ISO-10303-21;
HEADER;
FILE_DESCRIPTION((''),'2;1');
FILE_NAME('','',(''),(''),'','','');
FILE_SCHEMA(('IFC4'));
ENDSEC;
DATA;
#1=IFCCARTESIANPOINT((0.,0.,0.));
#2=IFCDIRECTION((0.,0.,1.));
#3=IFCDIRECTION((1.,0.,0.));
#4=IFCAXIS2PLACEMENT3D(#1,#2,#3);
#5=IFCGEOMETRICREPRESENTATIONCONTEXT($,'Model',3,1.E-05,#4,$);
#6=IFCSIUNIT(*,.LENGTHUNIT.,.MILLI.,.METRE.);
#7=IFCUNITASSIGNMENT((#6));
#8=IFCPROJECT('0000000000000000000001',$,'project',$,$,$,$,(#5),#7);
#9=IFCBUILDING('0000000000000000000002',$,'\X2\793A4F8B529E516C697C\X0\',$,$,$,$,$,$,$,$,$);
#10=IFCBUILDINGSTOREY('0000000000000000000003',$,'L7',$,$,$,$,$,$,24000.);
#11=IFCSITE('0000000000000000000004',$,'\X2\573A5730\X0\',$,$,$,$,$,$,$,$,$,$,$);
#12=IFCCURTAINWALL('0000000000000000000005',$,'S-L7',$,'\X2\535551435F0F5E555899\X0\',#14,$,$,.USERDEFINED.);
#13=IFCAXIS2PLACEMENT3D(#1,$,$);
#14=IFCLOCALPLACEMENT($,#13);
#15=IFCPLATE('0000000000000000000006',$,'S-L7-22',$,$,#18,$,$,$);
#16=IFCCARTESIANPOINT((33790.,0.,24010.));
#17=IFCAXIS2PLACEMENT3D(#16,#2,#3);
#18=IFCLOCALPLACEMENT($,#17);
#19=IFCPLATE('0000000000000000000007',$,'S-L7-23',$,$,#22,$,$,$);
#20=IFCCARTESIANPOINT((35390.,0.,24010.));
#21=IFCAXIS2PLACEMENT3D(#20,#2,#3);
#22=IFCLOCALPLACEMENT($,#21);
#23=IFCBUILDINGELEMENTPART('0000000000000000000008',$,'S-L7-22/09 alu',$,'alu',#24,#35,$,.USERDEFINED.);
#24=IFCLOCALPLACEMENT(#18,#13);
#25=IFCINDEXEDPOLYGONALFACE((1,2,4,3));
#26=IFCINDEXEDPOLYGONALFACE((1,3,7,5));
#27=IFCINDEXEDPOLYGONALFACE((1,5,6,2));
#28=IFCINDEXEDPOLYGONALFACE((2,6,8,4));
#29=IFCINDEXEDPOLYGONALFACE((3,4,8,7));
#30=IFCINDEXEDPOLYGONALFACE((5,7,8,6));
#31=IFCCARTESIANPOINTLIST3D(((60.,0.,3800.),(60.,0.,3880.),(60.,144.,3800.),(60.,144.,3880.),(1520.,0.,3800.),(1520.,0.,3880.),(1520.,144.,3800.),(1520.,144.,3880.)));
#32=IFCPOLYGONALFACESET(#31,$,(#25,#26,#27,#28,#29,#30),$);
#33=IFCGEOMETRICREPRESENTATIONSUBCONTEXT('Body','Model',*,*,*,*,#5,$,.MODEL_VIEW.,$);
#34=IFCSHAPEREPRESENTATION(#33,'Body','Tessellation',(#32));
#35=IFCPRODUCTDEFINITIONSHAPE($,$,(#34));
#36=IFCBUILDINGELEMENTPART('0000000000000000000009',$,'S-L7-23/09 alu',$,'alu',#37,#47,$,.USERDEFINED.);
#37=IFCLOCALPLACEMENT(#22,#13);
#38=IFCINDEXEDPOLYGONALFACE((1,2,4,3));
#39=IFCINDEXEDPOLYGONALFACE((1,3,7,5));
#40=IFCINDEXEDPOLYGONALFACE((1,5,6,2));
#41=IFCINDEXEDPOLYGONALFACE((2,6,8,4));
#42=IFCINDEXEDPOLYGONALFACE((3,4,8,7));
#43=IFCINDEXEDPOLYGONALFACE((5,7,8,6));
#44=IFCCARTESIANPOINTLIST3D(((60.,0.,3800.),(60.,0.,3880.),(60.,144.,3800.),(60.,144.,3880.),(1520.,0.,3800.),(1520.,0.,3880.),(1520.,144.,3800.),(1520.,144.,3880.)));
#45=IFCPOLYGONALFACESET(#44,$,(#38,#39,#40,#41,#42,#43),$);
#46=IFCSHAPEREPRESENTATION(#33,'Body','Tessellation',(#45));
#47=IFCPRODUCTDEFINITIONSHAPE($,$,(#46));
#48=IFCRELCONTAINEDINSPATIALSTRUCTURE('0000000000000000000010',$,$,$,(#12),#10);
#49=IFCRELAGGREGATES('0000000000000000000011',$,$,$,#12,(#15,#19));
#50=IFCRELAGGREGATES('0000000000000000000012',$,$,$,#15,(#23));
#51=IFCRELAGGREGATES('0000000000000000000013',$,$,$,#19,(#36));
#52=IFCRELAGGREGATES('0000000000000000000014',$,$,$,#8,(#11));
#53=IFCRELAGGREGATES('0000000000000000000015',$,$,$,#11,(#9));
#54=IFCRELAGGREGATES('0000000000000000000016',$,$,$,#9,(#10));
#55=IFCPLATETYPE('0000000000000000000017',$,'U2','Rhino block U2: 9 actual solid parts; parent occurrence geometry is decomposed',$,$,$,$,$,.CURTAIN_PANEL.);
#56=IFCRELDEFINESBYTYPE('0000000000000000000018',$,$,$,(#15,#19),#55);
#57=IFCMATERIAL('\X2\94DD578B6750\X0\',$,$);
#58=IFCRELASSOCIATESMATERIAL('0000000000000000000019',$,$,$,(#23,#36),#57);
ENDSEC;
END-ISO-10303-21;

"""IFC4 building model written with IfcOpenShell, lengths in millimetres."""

from ifc_helpers import new_model, si_unit, frame, frame_2d, origin, origin_with_axes, place, context, subcontext, project, spatial, rectangle, extrude, source, transform, mapped, material, type_object, element, aggregate, save


model = new_model("IFC4")

# Units and contexts
model_context = context("Model", 3, precision=1e-05, world=origin_with_axes())
body_context = subcontext(model_context, "Body", "Model", "MODEL_VIEW")
ifc_project = project(units=[si_unit("LENGTHUNIT", "METRE", prefix="MILLI")], contexts=[model_context])

# Site, building, storey
site = spatial("IfcSite", under=ifc_project, Name="场地")
building = spatial("IfcBuilding", under=site, Name="示例办公楼")
storey = spatial("IfcBuildingStorey", under=building, Name="L7", Elevation=24000.0)

# Curtain wall, plates, building element parts
curtain_wall = element("IfcCurtainWall", 1, inside=storey, Name="S-L7", ObjectType="单元式幕墙", PredefinedType="USERDEFINED")
plate_type = type_object("IfcPlateType", Name="U2", Description="Rhino block U2: 9 actual solid parts; parent occurrence geometry is decomposed", PredefinedType="CURTAIN_PANEL")
plate_1_placement = place(None, frame((33790.0, 0.0, 24010.0), z_axis=(0.0, 0.0, 1.0), x_axis=(1.0, 0.0, 0.0)))
plate_1 = element("IfcPlate", 2, at=plate_1_placement, type_object=plate_type, Name="S-L7-22")
ifc_material_1 = material(Name="铝型材")
plate_2_placement = place(None, frame((35390.0, 0.0, 24010.0), z_axis=(0.0, 0.0, 1.0), x_axis=(1.0, 0.0, 0.0)))
plate_2 = element("IfcPlate", 3, at=plate_2_placement, type_object=plate_type, Name="S-L7-23")
aggregate(curtain_wall, [plate_1, plate_2])
shared_shape_1 = source(origin(), body_context, "Body", "SweptSolid", [
    extrude(rectangle(XDim=1460.0, YDim=144.0, at=frame_2d((790.0, 72.0))), frame((0.0, 0.0, 3800.0)), (0.0, 0.0, 1.0), 80.0),
])
building_element_part_1_placement = place(plate_1_placement, origin())
building_element_part_1 = element("IfcBuildingElementPart", 4, at=building_element_part_1_placement, material=ifc_material_1, Name="S-L7-22/09 alu", ObjectType="alu", PredefinedType="USERDEFINED", context=body_context, shape_type="MappedRepresentation", body=[
    mapped(shared_shape_1, transform((0.0, 0.0, 0.0))),
])
aggregate(plate_1, [building_element_part_1])
building_element_part_2_placement = place(plate_2_placement, origin())
building_element_part_2 = element("IfcBuildingElementPart", 5, at=building_element_part_2_placement, material=ifc_material_1, Name="S-L7-23/09 alu", ObjectType="alu", PredefinedType="USERDEFINED", context=body_context, shape_type="MappedRepresentation", body=[
    mapped(shared_shape_1, transform((0.0, 0.0, 0.0))),
])
aggregate(plate_2, [building_element_part_2])

save(model, "model.ifc")
